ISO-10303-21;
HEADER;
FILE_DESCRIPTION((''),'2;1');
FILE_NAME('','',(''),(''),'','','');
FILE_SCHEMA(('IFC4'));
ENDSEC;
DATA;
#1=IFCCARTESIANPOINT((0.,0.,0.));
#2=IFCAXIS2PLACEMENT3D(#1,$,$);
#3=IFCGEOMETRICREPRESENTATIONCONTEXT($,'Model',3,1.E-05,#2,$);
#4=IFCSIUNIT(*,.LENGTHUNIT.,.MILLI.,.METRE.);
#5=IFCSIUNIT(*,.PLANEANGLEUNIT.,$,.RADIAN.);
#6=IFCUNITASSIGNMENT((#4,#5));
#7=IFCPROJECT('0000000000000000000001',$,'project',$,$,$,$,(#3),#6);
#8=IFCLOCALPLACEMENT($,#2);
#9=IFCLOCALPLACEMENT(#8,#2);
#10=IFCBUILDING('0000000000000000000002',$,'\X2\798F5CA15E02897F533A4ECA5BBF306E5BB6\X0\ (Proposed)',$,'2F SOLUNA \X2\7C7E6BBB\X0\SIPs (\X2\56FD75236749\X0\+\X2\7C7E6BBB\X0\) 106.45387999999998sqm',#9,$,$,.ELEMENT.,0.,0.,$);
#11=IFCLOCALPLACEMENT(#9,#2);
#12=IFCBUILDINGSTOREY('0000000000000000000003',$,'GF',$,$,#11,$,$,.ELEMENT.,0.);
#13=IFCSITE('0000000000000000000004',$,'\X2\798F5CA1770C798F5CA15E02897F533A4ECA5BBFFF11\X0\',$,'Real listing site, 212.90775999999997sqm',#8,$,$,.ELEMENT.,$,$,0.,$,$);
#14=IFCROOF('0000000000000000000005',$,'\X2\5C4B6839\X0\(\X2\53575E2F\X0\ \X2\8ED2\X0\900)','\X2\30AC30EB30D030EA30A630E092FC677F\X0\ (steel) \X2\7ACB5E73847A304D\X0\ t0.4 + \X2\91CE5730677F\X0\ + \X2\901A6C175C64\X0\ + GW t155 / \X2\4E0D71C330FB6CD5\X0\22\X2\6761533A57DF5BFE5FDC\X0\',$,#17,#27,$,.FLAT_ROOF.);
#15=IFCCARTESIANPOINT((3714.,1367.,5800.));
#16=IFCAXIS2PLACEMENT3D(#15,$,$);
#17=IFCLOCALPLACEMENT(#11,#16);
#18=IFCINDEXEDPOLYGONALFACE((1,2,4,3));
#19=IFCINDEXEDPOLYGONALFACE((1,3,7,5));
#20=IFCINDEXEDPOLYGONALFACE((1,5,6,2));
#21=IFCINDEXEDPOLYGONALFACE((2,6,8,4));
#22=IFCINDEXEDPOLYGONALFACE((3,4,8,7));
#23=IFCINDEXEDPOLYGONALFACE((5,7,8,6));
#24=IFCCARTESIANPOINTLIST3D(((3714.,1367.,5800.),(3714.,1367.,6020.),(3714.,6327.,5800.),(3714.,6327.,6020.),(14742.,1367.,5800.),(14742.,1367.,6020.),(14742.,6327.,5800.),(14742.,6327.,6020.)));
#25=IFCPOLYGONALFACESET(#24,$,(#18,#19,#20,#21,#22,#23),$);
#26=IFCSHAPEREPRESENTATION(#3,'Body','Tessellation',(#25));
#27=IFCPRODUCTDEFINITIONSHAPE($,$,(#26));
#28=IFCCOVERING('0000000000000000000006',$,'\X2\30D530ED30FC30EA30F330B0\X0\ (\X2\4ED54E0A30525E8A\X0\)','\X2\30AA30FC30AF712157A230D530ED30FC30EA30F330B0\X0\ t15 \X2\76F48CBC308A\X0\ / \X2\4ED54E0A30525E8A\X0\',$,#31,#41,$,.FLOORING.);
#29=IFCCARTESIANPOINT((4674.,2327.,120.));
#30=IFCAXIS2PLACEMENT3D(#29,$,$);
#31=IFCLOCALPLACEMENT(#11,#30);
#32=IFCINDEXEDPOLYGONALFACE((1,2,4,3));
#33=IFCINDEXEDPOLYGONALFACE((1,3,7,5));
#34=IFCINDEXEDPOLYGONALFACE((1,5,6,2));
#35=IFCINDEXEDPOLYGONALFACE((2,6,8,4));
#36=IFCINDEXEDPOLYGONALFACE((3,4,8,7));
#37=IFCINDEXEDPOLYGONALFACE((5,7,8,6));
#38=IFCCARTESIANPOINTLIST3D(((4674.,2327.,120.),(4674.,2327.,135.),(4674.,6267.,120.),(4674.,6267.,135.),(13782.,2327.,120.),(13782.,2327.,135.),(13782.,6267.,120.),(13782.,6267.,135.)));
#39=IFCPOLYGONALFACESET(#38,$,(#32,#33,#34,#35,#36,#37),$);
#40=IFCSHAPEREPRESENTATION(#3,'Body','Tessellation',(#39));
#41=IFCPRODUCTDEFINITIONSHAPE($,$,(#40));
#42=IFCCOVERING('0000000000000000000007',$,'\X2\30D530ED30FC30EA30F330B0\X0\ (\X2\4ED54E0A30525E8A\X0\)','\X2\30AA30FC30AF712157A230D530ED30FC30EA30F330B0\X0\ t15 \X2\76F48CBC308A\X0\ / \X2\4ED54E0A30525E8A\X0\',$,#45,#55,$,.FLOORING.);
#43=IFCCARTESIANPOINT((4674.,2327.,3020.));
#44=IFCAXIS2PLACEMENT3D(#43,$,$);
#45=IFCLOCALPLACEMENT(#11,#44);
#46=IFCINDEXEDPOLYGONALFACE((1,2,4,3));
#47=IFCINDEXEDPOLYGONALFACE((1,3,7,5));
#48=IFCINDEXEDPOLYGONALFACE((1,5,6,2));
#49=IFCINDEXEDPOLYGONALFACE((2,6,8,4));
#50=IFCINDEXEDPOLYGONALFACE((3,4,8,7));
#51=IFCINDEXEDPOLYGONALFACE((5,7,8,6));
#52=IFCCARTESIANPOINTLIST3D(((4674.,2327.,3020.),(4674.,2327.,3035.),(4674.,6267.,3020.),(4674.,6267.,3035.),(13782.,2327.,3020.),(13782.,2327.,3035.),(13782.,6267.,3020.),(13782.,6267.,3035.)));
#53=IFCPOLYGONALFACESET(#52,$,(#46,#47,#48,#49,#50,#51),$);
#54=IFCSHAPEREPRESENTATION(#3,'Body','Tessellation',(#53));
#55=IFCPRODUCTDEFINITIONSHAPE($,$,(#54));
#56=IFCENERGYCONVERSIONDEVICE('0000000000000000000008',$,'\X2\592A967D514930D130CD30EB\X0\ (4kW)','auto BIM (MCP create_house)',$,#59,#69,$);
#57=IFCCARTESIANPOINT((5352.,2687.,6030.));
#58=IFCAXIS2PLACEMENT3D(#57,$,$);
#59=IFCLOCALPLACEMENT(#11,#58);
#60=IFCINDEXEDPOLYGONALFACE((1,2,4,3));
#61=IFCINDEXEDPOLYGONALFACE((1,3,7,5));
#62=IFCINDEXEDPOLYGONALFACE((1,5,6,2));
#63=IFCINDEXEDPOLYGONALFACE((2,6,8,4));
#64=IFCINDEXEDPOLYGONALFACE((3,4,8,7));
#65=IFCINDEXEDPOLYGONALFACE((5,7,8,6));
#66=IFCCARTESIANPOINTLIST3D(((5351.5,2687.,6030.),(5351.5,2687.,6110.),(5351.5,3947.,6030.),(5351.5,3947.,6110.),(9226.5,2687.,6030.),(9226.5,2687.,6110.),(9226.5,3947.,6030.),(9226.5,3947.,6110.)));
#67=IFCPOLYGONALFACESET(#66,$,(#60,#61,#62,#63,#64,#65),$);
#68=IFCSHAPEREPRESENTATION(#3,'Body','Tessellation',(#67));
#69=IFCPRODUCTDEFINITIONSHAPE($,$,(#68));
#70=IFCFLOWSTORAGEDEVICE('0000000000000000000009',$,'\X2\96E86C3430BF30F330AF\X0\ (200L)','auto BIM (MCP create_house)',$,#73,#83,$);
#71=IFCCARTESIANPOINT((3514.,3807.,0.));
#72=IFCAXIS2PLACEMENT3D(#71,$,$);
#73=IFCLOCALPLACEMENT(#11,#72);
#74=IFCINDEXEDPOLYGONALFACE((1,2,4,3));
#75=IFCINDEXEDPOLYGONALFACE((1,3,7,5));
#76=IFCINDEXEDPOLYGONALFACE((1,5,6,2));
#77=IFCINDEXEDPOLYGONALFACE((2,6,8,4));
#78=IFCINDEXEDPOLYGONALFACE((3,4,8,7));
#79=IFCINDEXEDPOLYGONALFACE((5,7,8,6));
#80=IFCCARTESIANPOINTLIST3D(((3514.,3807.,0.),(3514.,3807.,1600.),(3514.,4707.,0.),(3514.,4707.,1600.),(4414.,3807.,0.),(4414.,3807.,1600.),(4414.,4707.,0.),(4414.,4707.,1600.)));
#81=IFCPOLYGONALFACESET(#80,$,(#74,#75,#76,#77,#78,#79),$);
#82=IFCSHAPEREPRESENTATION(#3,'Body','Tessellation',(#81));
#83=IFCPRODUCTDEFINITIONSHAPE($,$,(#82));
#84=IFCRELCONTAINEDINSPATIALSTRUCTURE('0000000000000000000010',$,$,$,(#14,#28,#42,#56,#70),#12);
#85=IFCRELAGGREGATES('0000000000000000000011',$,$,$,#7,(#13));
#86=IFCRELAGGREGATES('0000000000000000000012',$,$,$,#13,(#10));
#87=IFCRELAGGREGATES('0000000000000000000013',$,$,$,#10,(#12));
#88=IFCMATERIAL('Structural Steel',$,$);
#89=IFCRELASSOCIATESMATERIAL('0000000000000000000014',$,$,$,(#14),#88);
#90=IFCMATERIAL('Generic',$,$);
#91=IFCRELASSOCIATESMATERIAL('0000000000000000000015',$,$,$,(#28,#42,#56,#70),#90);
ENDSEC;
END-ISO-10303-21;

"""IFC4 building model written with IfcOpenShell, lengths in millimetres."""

from ifc_helpers import new_model, si_unit, frame, frame_2d, origin, place, context, project, spatial, rectangle, extrude, material, element, save


model = new_model("IFC4")

# Units and contexts
model_context = context("Model", 3, precision=1e-05, world=origin())
ifc_project = project(units=[si_unit("LENGTHUNIT", "METRE", prefix="MILLI"), si_unit("PLANEANGLEUNIT", "RADIAN")], contexts=[model_context])

# Site, building, storey
site_placement = place(None, origin())
site = spatial("IfcSite", under=ifc_project, at=site_placement, Name="福岡県福岡市西区今宿１", ObjectType="Real listing site, 212.90775999999997sqm", CompositionType="ELEMENT", RefElevation=0.0)
building_placement = place(site_placement, origin())
building = spatial("IfcBuilding", under=site, at=building_placement, Name="福岡市西区今宿の家 (Proposed)", ObjectType="2F SOLUNA 籾殻SIPs (国産杉+籾殻) 106.45387999999998sqm", CompositionType="ELEMENT", ElevationOfRefHeight=0.0, ElevationOfTerrain=0.0)
storey_placement = place(building_placement, origin())
storey = spatial("IfcBuildingStorey", under=building, at=storey_placement, Name="GF", CompositionType="ELEMENT", Elevation=0.0)

# Roof
ifc_material_1 = material(Name="Structural Steel")
for number, where, name in (
    (1, (3714.0, 1367.0, 5800.0), "屋根(南帯 軒900)"),
):
    element("IfcRoof", number, at=place(storey_placement, frame(where)), inside=storey, material=ifc_material_1, Name=name, Description="ガルバリウム鋼板 (steel) 立平葺き t0.4 + 野地板 + 通気層 + GW t155 / 不燃・法22条区域対応", PredefinedType="FLAT_ROOF", context=model_context, shape_type="SweptSolid", body=[
        extrude(rectangle(XDim=11028.0, YDim=4960.0, at=frame_2d((5514.0, 2480.0))), frame((3714.0, 1367.0, 5800.0)), (0.0, 0.0, 1.0), 220.0),
    ])

# Coverings
ifc_material_2 = material(Name="Generic")
covering_1_placement = place(storey_placement, frame((4674.0, 2327.0, 120.0)))
element("IfcCovering", 2, at=covering_1_placement, inside=storey, material=ifc_material_2, Name="フローリング (仕上げ床)", Description="オーク無垢フローリング t15 直貼り / 仕上げ床", PredefinedType="FLOORING", context=model_context, shape_type="SweptSolid", body=[
    extrude(rectangle(XDim=9108.0, YDim=3940.0, at=frame_2d((4554.0, 1970.0))), frame((4674.0, 2327.0, 120.0)), (0.0, 0.0, 1.0), 15.0),
])
covering_2_placement = place(storey_placement, frame((4674.0, 2327.0, 3020.0)))
element("IfcCovering", 3, at=covering_2_placement, inside=storey, material=ifc_material_2, Name="フローリング (仕上げ床)", Description="オーク無垢フローリング t15 直貼り / 仕上げ床", PredefinedType="FLOORING", context=model_context, shape_type="SweptSolid", body=[
    extrude(rectangle(XDim=9108.0, YDim=3940.0, at=frame_2d((4554.0, 1970.0))), frame((4674.0, 2327.0, 3020.0)), (0.0, 0.0, 1.0), 15.0),
])

# Energy conversion device
energy_conversion_device_placement = place(storey_placement, frame((5352.0, 2687.0, 6030.0)))
element("IfcEnergyConversionDevice", 4, at=energy_conversion_device_placement, inside=storey, material=ifc_material_2, Name="太陽光パネル (4kW)", Description="auto BIM (MCP create_house)", context=model_context, shape_type="SweptSolid", body=[
    extrude(rectangle(XDim=3875.0, YDim=1260.0, at=frame_2d((1937.0, 630.0))), frame((5352.0, 2687.0, 6030.0)), (0.0, 0.0, 1.0), 80.0),
])

# Flow storage device
flow_storage_device_placement = place(storey_placement, frame((3514.0, 3807.0, 0.0)))
element("IfcFlowStorageDevice", 5, at=flow_storage_device_placement, inside=storey, material=ifc_material_2, Name="雨水タンク (200L)", Description="auto BIM (MCP create_house)", context=model_context, shape_type="SweptSolid", body=[
    extrude(rectangle(XDim=900.0, YDim=900.0, at=frame_2d((450.0, 450.0))), frame((3514.0, 3807.0, 0.0)), (0.0, 0.0, 1.0), 1600.0),
])

save(model, "model.ifc")
